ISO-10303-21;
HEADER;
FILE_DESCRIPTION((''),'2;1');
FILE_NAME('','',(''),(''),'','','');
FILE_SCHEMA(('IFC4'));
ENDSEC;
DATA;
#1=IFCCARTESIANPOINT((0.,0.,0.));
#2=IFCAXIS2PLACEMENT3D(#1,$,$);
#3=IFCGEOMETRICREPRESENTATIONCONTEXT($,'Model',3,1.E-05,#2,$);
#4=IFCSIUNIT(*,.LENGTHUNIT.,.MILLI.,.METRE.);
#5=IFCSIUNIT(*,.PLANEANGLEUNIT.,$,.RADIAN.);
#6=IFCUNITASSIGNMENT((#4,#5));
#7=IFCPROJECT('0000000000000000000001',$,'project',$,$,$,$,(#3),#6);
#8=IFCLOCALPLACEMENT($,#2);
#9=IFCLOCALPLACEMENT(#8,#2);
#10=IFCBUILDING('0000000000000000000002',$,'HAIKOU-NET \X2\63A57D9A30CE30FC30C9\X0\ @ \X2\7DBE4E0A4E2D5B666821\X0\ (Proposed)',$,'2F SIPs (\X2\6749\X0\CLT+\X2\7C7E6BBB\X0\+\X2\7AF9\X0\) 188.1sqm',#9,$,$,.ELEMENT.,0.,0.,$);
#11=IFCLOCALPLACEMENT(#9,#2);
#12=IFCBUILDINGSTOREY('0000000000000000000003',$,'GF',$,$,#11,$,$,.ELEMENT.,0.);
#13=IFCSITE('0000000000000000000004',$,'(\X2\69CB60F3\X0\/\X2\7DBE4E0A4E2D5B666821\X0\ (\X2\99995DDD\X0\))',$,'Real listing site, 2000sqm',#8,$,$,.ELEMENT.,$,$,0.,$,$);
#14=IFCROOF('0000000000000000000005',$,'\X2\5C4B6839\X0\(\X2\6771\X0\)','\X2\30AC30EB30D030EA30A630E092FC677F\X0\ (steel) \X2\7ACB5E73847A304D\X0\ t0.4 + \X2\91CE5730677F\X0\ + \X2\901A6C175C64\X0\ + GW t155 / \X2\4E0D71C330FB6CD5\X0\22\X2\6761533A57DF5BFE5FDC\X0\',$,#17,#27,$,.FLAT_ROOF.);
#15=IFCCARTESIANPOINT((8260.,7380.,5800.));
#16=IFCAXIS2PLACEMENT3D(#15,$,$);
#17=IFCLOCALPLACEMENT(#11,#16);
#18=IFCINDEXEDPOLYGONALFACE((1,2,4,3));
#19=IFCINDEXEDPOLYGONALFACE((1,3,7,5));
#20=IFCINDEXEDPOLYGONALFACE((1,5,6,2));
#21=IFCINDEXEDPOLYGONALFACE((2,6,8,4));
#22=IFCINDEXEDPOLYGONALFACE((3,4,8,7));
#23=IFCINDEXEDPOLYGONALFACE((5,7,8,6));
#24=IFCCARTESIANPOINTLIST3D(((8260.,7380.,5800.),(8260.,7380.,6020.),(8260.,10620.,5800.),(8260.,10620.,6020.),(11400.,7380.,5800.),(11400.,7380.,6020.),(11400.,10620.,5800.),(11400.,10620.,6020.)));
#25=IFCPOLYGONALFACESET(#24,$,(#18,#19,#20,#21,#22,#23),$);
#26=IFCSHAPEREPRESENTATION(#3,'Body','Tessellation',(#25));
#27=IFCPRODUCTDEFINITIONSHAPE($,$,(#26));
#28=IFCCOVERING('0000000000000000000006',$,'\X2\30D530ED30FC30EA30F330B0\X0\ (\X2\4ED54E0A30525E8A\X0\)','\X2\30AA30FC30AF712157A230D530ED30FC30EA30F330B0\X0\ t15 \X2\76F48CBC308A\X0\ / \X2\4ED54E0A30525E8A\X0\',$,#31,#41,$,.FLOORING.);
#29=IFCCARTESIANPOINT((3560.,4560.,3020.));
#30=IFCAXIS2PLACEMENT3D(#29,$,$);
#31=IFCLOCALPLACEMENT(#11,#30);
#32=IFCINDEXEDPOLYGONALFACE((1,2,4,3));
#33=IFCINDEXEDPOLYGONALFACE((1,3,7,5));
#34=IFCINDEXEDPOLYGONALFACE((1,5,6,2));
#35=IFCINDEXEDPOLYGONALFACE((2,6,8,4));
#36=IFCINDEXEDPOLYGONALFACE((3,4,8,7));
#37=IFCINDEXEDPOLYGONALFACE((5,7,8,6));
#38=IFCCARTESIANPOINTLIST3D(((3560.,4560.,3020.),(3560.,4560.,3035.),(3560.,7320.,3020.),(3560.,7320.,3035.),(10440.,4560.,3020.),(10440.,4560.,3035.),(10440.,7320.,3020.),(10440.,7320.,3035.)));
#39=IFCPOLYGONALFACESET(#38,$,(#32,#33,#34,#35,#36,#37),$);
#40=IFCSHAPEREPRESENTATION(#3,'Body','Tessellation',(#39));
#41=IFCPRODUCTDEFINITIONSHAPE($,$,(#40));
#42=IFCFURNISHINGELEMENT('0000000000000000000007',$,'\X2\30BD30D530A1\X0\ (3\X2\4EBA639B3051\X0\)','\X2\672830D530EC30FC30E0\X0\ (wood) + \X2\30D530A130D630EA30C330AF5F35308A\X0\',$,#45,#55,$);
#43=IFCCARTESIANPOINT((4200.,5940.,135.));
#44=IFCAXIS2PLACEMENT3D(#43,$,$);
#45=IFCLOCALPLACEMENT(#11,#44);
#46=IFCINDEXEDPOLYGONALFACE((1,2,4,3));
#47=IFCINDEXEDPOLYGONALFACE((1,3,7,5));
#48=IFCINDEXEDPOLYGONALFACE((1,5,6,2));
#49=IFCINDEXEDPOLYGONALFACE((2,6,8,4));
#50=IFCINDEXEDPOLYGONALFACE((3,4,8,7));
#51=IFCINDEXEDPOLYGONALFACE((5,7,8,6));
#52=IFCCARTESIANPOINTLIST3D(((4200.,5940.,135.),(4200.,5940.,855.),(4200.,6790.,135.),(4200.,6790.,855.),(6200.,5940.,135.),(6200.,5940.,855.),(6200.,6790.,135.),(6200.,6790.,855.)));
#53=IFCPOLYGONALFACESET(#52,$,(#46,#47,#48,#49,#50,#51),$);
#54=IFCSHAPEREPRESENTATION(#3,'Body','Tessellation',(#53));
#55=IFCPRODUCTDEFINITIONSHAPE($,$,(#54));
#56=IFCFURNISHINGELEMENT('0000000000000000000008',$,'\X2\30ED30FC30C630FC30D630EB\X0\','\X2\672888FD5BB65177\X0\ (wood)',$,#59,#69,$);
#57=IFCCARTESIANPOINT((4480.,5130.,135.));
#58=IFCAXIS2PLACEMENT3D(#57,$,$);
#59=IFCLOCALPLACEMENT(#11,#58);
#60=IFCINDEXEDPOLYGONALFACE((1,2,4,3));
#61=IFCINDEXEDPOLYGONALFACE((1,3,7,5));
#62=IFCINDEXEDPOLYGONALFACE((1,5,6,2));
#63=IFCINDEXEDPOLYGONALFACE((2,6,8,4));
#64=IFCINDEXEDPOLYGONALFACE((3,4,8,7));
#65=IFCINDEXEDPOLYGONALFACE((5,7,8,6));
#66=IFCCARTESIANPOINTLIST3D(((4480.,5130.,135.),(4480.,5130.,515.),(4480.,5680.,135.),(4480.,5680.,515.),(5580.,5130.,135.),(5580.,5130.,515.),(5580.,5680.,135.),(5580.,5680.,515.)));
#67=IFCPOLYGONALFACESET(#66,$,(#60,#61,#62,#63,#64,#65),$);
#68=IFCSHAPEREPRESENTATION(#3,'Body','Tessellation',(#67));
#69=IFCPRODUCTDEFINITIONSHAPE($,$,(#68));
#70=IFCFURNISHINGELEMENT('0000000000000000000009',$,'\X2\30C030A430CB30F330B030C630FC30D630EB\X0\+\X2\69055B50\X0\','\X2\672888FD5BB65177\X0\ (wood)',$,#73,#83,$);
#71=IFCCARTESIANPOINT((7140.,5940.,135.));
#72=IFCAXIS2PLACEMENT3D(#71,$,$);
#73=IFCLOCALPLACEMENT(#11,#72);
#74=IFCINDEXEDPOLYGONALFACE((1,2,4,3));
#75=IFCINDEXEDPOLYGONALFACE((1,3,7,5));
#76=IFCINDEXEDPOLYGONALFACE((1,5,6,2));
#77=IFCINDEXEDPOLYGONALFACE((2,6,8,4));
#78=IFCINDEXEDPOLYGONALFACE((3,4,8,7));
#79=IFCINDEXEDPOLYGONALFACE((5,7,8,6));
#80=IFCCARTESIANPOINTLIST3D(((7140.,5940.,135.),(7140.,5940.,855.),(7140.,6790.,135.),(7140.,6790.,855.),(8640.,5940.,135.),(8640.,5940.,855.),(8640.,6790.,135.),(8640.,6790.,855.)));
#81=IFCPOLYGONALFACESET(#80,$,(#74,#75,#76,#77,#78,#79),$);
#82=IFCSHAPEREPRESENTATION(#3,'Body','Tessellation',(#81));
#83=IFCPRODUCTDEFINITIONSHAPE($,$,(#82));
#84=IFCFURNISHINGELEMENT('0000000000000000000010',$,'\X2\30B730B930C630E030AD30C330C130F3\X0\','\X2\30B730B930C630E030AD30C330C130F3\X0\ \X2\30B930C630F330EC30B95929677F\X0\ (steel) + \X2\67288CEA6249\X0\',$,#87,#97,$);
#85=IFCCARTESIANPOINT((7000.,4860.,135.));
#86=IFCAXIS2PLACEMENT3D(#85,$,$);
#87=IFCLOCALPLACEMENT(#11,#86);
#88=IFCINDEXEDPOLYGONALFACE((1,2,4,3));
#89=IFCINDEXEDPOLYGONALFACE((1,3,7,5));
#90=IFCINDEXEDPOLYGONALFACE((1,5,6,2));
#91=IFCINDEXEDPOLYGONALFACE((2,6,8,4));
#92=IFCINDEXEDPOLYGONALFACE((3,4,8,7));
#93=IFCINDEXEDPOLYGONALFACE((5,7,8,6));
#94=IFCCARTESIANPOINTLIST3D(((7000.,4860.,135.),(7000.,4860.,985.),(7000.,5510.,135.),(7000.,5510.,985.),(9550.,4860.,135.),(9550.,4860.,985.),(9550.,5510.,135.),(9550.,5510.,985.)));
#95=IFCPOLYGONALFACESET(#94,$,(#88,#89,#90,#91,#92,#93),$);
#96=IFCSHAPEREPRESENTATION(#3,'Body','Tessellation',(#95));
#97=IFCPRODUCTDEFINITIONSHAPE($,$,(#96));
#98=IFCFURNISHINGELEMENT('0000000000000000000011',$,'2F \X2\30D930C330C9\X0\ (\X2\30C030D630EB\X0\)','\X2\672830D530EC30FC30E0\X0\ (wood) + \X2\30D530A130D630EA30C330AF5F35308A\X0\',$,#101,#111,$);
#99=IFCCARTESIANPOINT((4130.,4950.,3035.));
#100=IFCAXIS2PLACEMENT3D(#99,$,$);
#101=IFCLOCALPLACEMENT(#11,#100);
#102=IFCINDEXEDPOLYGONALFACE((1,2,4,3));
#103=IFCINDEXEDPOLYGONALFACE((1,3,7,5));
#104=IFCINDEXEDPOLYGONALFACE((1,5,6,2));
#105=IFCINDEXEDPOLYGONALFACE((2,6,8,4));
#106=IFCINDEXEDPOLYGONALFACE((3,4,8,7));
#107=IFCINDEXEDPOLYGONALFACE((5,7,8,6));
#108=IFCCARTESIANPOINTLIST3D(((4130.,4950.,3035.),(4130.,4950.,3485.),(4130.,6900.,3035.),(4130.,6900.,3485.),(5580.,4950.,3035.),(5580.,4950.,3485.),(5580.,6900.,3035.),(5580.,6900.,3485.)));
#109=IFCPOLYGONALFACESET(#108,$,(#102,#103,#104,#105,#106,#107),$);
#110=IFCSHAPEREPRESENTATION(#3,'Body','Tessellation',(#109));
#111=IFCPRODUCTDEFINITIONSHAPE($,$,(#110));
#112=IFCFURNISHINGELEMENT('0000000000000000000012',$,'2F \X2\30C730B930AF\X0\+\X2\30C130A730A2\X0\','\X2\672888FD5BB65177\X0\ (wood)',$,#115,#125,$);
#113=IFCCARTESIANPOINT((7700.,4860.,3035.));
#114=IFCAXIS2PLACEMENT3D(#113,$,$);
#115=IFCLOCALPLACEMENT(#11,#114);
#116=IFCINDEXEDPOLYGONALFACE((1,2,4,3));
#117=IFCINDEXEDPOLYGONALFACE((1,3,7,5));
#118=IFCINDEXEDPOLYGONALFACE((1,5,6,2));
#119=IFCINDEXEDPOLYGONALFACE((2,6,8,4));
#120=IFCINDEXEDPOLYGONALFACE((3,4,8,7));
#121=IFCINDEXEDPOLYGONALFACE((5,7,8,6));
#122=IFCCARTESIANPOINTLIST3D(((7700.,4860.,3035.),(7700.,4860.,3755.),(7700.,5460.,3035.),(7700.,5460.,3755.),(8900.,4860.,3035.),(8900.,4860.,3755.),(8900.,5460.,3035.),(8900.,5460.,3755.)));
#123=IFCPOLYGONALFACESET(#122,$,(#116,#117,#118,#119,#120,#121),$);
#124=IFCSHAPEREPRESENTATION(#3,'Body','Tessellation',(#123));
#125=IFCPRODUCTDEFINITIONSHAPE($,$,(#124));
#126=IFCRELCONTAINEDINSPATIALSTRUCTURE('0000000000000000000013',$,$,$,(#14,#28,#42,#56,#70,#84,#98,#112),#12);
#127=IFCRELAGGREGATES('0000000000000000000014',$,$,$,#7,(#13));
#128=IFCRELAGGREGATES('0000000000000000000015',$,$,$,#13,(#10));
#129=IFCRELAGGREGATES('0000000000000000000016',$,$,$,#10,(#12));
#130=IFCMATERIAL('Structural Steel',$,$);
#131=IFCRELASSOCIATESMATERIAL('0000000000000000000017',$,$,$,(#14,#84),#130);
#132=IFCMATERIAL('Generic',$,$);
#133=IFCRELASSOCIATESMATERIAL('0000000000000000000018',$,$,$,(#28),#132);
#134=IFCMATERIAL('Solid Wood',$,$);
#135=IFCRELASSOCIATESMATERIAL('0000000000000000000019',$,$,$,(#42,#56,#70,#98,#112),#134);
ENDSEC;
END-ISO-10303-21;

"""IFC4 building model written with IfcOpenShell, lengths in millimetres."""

from ifc_helpers import new_model, si_unit, frame, frame_2d, origin, place, context, project, spatial, rectangle, extrude, material, element, save


model = new_model("IFC4")

# Units and contexts
model_context = context("Model", 3, precision=1e-05, world=origin())
ifc_project = project(units=[si_unit("LENGTHUNIT", "METRE", prefix="MILLI"), si_unit("PLANEANGLEUNIT", "RADIAN")], contexts=[model_context])

# Site, building, storey
site_placement = place(None, origin())
site = spatial("IfcSite", under=ifc_project, at=site_placement, Name="(構想/綾上中学校 (香川))", ObjectType="Real listing site, 2000sqm", CompositionType="ELEMENT", RefElevation=0.0)
building_placement = place(site_placement, origin())
building = spatial("IfcBuilding", under=site, at=building_placement, Name="HAIKOU-NET 接続ノード @ 綾上中学校 (Proposed)", ObjectType="2F SIPs (杉CLT+籾殻+竹) 188.1sqm", CompositionType="ELEMENT", ElevationOfRefHeight=0.0, ElevationOfTerrain=0.0)
storey_placement = place(building_placement, origin())
storey = spatial("IfcBuildingStorey", under=building, at=storey_placement, Name="GF", CompositionType="ELEMENT", Elevation=0.0)

# Shared definitions
ifc_material_1 = material(Name="Solid Wood")

# Shared definitions
ifc_material_2 = material(Name="Generic")

# Roof
ifc_material_3 = material(Name="Structural Steel")
roof_placement = place(storey_placement, frame((8260.0, 7380.0, 5800.0)))
element("IfcRoof", 1, at=roof_placement, inside=storey, material=ifc_material_3, Name="屋根(東)", Description="ガルバリウム鋼板 (steel) 立平葺き t0.4 + 野地板 + 通気層 + GW t155 / 不燃・法22条区域対応", PredefinedType="FLAT_ROOF", context=model_context, shape_type="SweptSolid", body=[
    extrude(rectangle(XDim=3140.0, YDim=3240.0, at=frame_2d((1570.0, 1620.0))), frame((8260.0, 7380.0, 5800.0)), (0.0, 0.0, 1.0), 220.0),
])

# Covering
covering_placement = place(storey_placement, frame((3560.0, 4560.0, 3020.0)))
element("IfcCovering", 2, at=covering_placement, inside=storey, material=ifc_material_2, Name="フローリング (仕上げ床)", Description="オーク無垢フローリング t15 直貼り / 仕上げ床", PredefinedType="FLOORING", context=model_context, shape_type="SweptSolid", body=[
    extrude(rectangle(XDim=6880.0, YDim=2760.0, at=frame_2d((3440.0, 1380.0))), frame((3560.0, 4560.0, 3020.0)), (0.0, 0.0, 1.0), 15.0),
])

# Furnishing elements
furnishing_1_placement = place(storey_placement, frame((4200.0, 5940.0, 135.0)))
element("IfcFurnishingElement", 3, at=furnishing_1_placement, inside=storey, material=ifc_material_1, Name="ソファ (3人掛け)", Description="木フレーム (wood) + ファブリック張り", context=model_context, shape_type="SweptSolid", body=[
    extrude(rectangle(XDim=2000.0, YDim=850.0, at=frame_2d((1000.0, 425.0))), frame((4200.0, 5940.0, 135.0)), (0.0, 0.0, 1.0), 720.0),
])
furnishing_2_placement = place(storey_placement, frame((4480.0, 5130.0, 135.0)))
element("IfcFurnishingElement", 4, at=furnishing_2_placement, inside=storey, material=ifc_material_1, Name="ローテーブル", Description="木製家具 (wood)", context=model_context, shape_type="SweptSolid", body=[
    extrude(rectangle(XDim=1100.0, YDim=550.0, at=frame_2d((550.0, 275.0))), frame((4480.0, 5130.0, 135.0)), (0.0, 0.0, 1.0), 380.0),
])
furnishing_3_placement = place(storey_placement, frame((7140.0, 5940.0, 135.0)))
element("IfcFurnishingElement", 5, at=furnishing_3_placement, inside=storey, material=ifc_material_1, Name="ダイニングテーブル+椅子", Description="木製家具 (wood)", context=model_context, shape_type="SweptSolid", body=[
    extrude(rectangle(XDim=1500.0, YDim=850.0, at=frame_2d((750.0, 425.0))), frame((7140.0, 5940.0, 135.0)), (0.0, 0.0, 1.0), 720.0),
])
furnishing_4_placement = place(storey_placement, frame((7000.0, 4860.0, 135.0)))
element("IfcFurnishingElement", 6, at=furnishing_4_placement, inside=storey, material=ifc_material_3, Name="システムキッチン", Description="システムキッチン ステンレス天板 (steel) + 木質扉", context=model_context, shape_type="SweptSolid", body=[
    extrude(rectangle(XDim=2550.0, YDim=650.0, at=frame_2d((1275.0, 325.0))), frame((7000.0, 4860.0, 135.0)), (0.0, 0.0, 1.0), 850.0),
])
furnishing_5_placement = place(storey_placement, frame((4130.0, 4950.0, 3035.0)))
element("IfcFurnishingElement", 7, at=furnishing_5_placement, inside=storey, material=ifc_material_1, Name="2F ベッド (ダブル)", Description="木フレーム (wood) + ファブリック張り", context=model_context, shape_type="SweptSolid", body=[
    extrude(rectangle(XDim=1450.0, YDim=1950.0, at=frame_2d((725.0, 975.0))), frame((4130.0, 4950.0, 3035.0)), (0.0, 0.0, 1.0), 450.0),
])
furnishing_6_placement = place(storey_placement, frame((7700.0, 4860.0, 3035.0)))
element("IfcFurnishingElement", 8, at=furnishing_6_placement, inside=storey, material=ifc_material_1, Name="2F デスク+チェア", Description="木製家具 (wood)", context=model_context, shape_type="SweptSolid", body=[
    extrude(rectangle(XDim=1200.0, YDim=600.0, at=frame_2d((600.0, 300.0))), frame((7700.0, 4860.0, 3035.0)), (0.0, 0.0, 1.0), 720.0),
])

save(model, "model.ifc")
